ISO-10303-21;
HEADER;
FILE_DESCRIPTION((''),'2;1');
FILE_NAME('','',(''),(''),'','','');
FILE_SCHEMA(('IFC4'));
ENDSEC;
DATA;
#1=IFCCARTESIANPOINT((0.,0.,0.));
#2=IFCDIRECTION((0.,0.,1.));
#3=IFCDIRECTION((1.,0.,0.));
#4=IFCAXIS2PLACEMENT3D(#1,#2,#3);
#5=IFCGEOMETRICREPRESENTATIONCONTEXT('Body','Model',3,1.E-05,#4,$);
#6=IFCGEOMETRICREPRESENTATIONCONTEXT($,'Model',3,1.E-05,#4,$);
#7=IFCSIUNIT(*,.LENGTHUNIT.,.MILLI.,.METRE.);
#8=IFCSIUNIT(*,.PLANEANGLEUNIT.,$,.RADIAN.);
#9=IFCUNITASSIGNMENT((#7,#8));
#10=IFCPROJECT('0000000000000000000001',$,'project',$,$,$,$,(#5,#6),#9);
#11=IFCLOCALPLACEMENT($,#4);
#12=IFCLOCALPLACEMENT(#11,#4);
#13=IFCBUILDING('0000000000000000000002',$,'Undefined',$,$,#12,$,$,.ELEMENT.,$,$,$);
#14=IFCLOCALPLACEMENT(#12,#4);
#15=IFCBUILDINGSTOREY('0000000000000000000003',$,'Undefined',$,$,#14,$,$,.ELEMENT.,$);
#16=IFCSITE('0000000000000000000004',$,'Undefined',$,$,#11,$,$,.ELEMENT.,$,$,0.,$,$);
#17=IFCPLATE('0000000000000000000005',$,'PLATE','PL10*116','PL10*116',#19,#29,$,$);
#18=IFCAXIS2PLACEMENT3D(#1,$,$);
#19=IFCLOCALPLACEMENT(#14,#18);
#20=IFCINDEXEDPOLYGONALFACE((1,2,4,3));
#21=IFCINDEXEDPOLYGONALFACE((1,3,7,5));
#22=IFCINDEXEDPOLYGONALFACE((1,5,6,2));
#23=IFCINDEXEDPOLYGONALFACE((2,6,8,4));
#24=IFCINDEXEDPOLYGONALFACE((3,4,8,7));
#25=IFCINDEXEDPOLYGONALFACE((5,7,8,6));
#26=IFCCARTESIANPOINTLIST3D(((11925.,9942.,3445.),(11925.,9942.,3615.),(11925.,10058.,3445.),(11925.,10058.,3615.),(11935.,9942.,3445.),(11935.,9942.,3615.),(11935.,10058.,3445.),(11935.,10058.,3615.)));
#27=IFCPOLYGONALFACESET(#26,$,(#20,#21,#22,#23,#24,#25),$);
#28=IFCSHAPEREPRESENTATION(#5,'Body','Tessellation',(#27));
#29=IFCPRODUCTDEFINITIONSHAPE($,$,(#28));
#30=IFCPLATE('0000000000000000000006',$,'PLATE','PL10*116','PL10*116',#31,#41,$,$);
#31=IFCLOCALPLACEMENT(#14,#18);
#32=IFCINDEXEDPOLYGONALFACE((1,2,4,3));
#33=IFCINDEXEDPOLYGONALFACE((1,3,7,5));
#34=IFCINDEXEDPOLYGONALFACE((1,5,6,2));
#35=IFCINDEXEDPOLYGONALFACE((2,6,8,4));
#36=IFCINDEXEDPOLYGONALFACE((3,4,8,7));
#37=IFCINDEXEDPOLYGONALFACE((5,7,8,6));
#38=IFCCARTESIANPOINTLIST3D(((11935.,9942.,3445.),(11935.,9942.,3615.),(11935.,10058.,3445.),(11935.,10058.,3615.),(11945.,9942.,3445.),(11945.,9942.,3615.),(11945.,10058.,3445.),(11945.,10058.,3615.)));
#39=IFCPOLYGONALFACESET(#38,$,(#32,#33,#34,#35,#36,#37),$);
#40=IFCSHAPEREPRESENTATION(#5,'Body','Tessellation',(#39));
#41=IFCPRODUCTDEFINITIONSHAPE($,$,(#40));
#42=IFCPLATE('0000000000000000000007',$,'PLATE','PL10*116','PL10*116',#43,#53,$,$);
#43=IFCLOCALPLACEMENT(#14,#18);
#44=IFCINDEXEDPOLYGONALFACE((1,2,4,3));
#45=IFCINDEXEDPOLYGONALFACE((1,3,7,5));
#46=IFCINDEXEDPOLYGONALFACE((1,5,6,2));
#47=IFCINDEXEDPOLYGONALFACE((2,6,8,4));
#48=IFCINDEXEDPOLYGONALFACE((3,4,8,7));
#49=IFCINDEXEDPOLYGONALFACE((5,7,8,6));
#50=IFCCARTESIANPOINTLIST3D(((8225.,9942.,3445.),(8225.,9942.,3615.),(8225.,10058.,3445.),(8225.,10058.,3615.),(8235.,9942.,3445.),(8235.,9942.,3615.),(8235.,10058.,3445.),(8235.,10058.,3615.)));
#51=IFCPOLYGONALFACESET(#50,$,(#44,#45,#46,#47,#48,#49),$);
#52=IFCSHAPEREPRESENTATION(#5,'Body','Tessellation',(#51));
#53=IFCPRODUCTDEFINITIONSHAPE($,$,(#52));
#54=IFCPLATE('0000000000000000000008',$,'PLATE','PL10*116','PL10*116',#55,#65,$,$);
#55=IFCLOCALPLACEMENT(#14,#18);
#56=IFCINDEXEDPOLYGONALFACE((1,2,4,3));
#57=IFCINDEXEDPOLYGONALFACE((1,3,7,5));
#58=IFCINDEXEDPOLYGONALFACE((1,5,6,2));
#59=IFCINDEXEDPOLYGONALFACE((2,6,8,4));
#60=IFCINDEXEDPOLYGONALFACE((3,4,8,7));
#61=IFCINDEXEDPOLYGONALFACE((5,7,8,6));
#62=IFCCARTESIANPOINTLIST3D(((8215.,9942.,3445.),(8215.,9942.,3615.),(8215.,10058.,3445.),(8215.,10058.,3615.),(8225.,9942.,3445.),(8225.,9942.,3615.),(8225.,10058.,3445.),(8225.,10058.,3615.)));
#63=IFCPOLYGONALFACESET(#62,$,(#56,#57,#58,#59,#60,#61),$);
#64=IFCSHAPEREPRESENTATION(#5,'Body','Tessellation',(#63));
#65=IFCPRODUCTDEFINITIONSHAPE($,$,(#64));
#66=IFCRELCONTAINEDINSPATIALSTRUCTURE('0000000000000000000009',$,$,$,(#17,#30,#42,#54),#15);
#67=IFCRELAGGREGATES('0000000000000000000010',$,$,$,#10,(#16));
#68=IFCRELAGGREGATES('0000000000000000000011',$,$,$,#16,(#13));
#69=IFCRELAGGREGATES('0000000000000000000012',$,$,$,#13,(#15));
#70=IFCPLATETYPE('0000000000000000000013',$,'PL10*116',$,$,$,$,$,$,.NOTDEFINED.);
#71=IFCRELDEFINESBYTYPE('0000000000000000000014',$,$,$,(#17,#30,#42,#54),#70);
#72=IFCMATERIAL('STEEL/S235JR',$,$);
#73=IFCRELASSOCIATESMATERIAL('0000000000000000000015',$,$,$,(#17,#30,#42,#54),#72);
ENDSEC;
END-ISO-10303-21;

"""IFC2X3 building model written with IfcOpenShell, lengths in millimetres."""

from ifc_helpers import new_model, si_unit, frame, origin_with_axes, place, context, project, spatial, polyline, outline, extrude, material, type_object, element, save


model = new_model("IFC2X3")

# Units and contexts
model_context_1 = context("Model", 3, precision=1e-05, world=origin_with_axes(), identifier="Body")
model_context_2 = context("Model", 3, precision=1e-05, world=origin_with_axes())
ifc_project = project(units=[si_unit("LENGTHUNIT", "METRE", prefix="MILLI"), si_unit("PLANEANGLEUNIT", "RADIAN")], contexts=[model_context_1, model_context_2])

# Site, building, storey
site_placement = place(None, origin_with_axes())
site = spatial("IfcSite", under=ifc_project, at=site_placement, Name="Undefined", CompositionType="ELEMENT", RefElevation=0.0)
building_placement = place(site_placement, origin_with_axes())
building = spatial("IfcBuilding", under=site, at=building_placement, Name="Undefined", CompositionType="ELEMENT")
storey_placement = place(building_placement, origin_with_axes())
storey = spatial("IfcBuildingStorey", under=building, at=storey_placement, Name="Undefined", CompositionType="ELEMENT")

# Shared definitions
ifc_material = material(Name="STEEL/S235JR")

# Plates
plate_type_1 = type_object("IfcPlateType", Name="PL10*116", PredefinedType="NOTDEFINED")
for number, where, z_axis, x_axis, name in (
    (1, (11930.0, 10058.0, 3615.0), (1.0, 0.0, 0.0), (0.0, -1.0, 0.0), "PLATE"),
    (2, (11940.0, 10058.0, 3615.0), (1.0, 0.0, 0.0), (0.0, -1.0, 0.0), "PLATE"),
    (3, (8230.0, 10058.0, 3615.0), (1.0, 0.0, 0.0), (0.0, -1.0, 0.0), "PLATE"),
    (4, (8220.0, 10058.0, 3615.0), (1.0, 0.0, 0.0), (0.0, -1.0, 0.0), "PLATE"),
):
    element("IfcPlate", number, at=place(storey_placement, frame(where, z_axis=z_axis, x_axis=x_axis)), inside=storey, type_object=plate_type_1, material=ifc_material, Name=name, Description="PL10*116", ObjectType="PL10*116", context=model_context_1, shape_type="SweptSolid", body=[
        extrude(outline(polyline([(0.0, 0.0), (116.0, 0.0), (116.0, 170.0), (0.0, 170.0), (0.0, 0.0)])), frame((0.0, 0.0, -5.0), z_axis=(0.0, 0.0, 1.0), x_axis=(1.0, 0.0, 0.0)), (0.0, 0.0, 1.0), 10.0),
    ])

save(model, "model.ifc")
